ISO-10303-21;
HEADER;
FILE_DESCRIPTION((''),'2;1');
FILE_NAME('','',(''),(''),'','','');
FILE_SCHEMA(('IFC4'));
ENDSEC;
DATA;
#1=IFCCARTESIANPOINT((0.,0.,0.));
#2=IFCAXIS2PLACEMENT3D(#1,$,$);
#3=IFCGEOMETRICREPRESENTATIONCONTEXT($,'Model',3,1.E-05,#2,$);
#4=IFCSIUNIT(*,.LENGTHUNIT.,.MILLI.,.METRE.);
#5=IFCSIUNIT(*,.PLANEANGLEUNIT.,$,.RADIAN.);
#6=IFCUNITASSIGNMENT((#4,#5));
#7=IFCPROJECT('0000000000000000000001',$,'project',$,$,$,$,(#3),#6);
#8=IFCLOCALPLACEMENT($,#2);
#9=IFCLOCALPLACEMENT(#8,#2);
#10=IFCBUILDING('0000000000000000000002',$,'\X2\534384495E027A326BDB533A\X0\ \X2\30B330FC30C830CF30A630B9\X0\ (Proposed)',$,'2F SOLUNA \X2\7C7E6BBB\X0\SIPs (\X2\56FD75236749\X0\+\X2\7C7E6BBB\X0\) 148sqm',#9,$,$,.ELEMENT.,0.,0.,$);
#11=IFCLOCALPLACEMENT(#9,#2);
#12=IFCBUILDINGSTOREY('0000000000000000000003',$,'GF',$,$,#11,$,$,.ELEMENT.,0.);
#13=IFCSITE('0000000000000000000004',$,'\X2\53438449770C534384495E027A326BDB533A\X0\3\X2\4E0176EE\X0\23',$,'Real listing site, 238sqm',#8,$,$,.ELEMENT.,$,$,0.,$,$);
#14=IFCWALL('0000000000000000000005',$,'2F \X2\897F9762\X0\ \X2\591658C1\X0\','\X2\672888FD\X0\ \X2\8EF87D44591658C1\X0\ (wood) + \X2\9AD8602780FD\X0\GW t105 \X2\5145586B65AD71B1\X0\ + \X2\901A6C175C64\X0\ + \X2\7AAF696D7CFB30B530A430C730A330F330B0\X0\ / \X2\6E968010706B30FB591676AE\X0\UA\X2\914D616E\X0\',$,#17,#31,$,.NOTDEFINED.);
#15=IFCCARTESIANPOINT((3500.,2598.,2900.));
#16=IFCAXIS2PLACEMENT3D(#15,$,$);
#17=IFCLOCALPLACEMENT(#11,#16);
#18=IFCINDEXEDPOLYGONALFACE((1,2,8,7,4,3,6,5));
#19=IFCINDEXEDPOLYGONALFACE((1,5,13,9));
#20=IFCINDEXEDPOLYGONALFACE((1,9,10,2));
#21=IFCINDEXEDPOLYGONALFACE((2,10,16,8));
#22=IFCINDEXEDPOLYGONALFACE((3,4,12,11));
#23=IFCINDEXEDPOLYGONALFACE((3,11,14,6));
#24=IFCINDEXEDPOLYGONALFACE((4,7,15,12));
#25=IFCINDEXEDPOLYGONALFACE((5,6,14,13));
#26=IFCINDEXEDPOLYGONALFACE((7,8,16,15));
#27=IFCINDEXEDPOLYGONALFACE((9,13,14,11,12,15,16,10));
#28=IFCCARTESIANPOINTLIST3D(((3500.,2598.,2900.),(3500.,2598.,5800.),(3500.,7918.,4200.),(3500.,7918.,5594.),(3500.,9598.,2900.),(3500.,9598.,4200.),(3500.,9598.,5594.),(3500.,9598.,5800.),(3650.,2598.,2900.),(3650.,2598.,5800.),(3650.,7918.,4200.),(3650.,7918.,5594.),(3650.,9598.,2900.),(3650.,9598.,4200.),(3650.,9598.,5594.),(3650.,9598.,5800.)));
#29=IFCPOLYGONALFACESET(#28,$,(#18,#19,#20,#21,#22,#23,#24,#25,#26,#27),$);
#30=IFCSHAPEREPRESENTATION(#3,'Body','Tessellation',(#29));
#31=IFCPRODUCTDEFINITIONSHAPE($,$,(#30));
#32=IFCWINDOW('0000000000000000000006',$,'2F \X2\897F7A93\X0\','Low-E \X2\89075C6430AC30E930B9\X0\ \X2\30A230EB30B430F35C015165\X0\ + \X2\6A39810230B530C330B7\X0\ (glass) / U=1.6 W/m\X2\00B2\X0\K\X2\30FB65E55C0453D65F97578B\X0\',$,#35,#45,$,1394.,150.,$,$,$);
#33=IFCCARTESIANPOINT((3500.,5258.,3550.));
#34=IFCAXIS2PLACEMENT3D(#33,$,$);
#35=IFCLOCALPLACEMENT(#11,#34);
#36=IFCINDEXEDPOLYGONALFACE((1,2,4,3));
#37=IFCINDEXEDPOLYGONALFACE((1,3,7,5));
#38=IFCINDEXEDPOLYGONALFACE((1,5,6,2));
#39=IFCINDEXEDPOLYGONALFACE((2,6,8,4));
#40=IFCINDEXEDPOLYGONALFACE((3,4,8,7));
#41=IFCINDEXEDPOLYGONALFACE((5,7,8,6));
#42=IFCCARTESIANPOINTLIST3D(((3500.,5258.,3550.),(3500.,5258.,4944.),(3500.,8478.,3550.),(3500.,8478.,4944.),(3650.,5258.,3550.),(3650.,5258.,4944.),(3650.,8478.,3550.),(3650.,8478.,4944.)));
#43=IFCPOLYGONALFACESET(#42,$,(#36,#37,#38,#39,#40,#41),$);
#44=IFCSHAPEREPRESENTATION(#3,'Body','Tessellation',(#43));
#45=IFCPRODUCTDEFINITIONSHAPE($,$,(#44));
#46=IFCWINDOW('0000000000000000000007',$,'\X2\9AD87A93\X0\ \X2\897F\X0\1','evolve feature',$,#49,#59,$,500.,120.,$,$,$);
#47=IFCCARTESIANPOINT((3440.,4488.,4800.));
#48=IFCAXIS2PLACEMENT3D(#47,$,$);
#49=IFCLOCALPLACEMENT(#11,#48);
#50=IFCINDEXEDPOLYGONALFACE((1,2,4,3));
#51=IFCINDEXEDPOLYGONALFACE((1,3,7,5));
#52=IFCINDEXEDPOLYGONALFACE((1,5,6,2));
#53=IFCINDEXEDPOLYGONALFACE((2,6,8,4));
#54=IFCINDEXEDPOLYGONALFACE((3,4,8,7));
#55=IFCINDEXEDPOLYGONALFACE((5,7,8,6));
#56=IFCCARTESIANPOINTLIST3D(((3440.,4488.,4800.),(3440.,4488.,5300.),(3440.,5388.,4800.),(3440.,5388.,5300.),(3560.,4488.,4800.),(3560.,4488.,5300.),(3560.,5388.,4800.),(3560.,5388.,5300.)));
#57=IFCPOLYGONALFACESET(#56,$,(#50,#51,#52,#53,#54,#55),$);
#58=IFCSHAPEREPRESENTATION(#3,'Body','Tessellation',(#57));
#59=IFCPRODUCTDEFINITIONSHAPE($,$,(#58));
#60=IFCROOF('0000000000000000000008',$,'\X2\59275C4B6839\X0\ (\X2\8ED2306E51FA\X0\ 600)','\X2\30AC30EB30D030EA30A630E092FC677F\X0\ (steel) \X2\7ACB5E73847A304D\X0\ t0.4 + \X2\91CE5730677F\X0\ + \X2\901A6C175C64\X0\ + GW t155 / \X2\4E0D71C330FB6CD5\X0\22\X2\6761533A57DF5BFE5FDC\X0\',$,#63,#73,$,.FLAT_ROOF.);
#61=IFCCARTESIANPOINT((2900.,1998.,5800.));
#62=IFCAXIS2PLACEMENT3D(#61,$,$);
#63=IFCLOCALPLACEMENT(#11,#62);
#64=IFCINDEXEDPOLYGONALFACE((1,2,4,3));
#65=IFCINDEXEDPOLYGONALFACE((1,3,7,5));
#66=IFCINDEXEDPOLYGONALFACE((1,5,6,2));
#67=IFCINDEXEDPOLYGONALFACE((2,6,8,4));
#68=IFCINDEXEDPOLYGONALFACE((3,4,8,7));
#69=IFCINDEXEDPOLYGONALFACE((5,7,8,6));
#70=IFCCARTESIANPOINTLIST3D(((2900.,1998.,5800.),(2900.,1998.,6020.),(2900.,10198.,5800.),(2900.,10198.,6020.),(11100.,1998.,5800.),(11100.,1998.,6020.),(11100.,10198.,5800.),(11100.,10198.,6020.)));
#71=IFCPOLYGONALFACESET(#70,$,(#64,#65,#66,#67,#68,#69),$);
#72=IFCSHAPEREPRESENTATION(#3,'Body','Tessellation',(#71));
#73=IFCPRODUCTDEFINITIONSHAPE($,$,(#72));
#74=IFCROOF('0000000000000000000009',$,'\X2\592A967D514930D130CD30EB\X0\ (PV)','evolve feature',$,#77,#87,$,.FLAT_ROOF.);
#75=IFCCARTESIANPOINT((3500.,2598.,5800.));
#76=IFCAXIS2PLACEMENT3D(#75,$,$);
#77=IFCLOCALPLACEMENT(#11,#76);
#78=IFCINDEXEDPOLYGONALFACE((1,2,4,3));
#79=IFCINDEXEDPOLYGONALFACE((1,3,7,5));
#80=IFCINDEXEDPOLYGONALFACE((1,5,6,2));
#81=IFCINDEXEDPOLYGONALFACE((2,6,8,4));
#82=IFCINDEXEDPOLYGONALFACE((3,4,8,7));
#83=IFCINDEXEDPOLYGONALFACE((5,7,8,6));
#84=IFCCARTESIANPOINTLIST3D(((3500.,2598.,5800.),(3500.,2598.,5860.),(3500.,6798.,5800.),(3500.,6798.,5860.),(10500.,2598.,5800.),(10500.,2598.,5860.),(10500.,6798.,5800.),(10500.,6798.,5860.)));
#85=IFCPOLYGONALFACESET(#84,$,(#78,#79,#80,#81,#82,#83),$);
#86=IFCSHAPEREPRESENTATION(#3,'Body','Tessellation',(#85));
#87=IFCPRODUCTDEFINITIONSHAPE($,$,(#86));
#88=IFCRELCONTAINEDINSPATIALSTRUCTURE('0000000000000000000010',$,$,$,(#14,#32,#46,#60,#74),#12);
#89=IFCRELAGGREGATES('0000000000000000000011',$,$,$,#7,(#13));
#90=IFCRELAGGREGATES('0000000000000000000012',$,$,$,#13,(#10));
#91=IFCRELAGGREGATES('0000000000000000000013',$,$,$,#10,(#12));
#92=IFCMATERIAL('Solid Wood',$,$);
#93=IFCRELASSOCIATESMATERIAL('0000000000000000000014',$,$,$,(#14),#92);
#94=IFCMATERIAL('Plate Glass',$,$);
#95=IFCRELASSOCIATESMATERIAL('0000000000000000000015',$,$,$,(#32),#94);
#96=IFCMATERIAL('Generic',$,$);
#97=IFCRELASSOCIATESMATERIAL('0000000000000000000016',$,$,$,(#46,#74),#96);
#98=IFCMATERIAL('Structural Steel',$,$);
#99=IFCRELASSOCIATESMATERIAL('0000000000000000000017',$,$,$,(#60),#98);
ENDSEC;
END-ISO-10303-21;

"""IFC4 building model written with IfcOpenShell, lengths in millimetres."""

from ifc_helpers import new_model, si_unit, frame, frame_2d, origin, place, context, project, spatial, rectangle, extrude, material, element, fill, save


model = new_model("IFC4")

# Units and contexts
model_context = context("Model", 3, precision=1e-05, world=origin())
ifc_project = project(units=[si_unit("LENGTHUNIT", "METRE", prefix="MILLI"), si_unit("PLANEANGLEUNIT", "RADIAN")], contexts=[model_context])

# Site, building, storey
site_placement = place(None, origin())
site = spatial("IfcSite", under=ifc_project, at=site_placement, Name="千葉県千葉市稲毛区3丁目23", ObjectType="Real listing site, 238sqm", CompositionType="ELEMENT", RefElevation=0.0)
building_placement = place(site_placement, origin())
building = spatial("IfcBuilding", under=site, at=building_placement, Name="千葉市稲毛区 コートハウス (Proposed)", ObjectType="2F SOLUNA 籾殻SIPs (国産杉+籾殻) 148sqm", CompositionType="ELEMENT", ElevationOfRefHeight=0.0, ElevationOfTerrain=0.0)
storey_placement = place(building_placement, origin())
storey = spatial("IfcBuildingStorey", under=building, at=storey_placement, Name="GF", CompositionType="ELEMENT", Elevation=0.0)

# Shared definitions
ifc_material_1 = material(Name="Solid Wood")
ifc_material_2 = material(Name="Generic")

# Shared definitions
ifc_material_3 = material(Name="Plate Glass")

# Wall, openings, windows
wall_1_placement = place(storey_placement, frame((3500.0, 2598.0, 2900.0)))
wall_1 = element("IfcWall", 1, at=wall_1_placement, inside=storey, material=ifc_material_1, Name="2F 西面 外壁", Description="木製 軸組外壁 (wood) + 高性能GW t105 充填断熱 + 通気層 + 窯業系サイディング / 準耐火・外皮UA配慮", PredefinedType="NOTDEFINED", context=model_context, shape_type="SweptSolid", body=[
    extrude(rectangle(XDim=150.0, YDim=7000.0, at=frame_2d((75.0, 3500.0))), frame((3500.0, 2598.0, 2900.0)), (0.0, 0.0, 1.0), 2900.0),
])
opening_1_placement = place(storey_placement, frame((3500.0, 5258.0, 3550.0)))
opening_1 = element("IfcOpeningElement", 2, at=opening_1_placement, cuts=wall_1, PredefinedType="NOTDEFINED", context=model_context, shape_type="SweptSolid", body=[
    extrude(rectangle(XDim=150.0, YDim=3220.0, at=frame_2d((75.0, 1610.0))), frame((3500.0, 5258.0, 3550.0)), (0.0, 0.0, 1.0), 1394.0),
])
opening_2_placement = place(storey_placement, frame((3440.0, 4488.0, 4800.0)))
opening_2 = element("IfcOpeningElement", 3, at=opening_2_placement, cuts=wall_1, PredefinedType="NOTDEFINED", context=model_context, shape_type="SweptSolid", body=[
    extrude(rectangle(XDim=120.0, YDim=900.0, at=frame_2d((60.0, 450.0))), frame((3440.0, 4488.0, 4800.0)), (0.0, 0.0, 1.0), 500.0),
])
window_1_placement = place(storey_placement, frame((3500.0, 5258.0, 3550.0)))
window_1 = element("IfcWindow", 4, at=window_1_placement, inside=storey, material=ifc_material_3, Name="2F 西窓", Description="Low-E 複層ガラス アルゴン封入 + 樹脂サッシ (glass) / U=1.6 W/m²K・日射取得型", OverallHeight=1394.0, OverallWidth=150.0, context=model_context, shape_type="SweptSolid", body=[
    extrude(rectangle(XDim=150.0, YDim=3220.0, at=frame_2d((75.0, 1610.0))), frame((3500.0, 5258.0, 3550.0)), (0.0, 0.0, 1.0), 1394.0),
])
fill(opening_1, window_1)
window_2_placement = place(storey_placement, frame((3440.0, 4488.0, 4800.0)))
window_2 = element("IfcWindow", 5, at=window_2_placement, inside=storey, material=ifc_material_2, Name="高窓 西1", Description="evolve feature", OverallHeight=500.0, OverallWidth=120.0, context=model_context, shape_type="SweptSolid", body=[
    extrude(rectangle(XDim=120.0, YDim=900.0, at=frame_2d((60.0, 450.0))), frame((3440.0, 4488.0, 4800.0)), (0.0, 0.0, 1.0), 500.0),
])
fill(opening_2, window_2)

# Roofs
ifc_material_4 = material(Name="Structural Steel")
roof_1_placement = place(storey_placement, frame((2900.0, 1998.0, 5800.0)))
element("IfcRoof", 6, at=roof_1_placement, inside=storey, material=ifc_material_4, Name="大屋根 (軒の出 600)", Description="ガルバリウム鋼板 (steel) 立平葺き t0.4 + 野地板 + 通気層 + GW t155 / 不燃・法22条区域対応", PredefinedType="FLAT_ROOF", context=model_context, shape_type="SweptSolid", body=[
    extrude(rectangle(XDim=8200.0, YDim=8200.0, at=frame_2d((4100.0, 4100.0))), frame((2900.0, 1998.0, 5800.0)), (0.0, 0.0, 1.0), 220.0),
])
roof_2_placement = place(storey_placement, frame((3500.0, 2598.0, 5800.0)))
element("IfcRoof", 7, at=roof_2_placement, inside=storey, material=ifc_material_2, Name="太陽光パネル (PV)", Description="evolve feature", PredefinedType="FLAT_ROOF", context=model_context, shape_type="SweptSolid", body=[
    extrude(rectangle(XDim=7000.0, YDim=4200.0, at=frame_2d((3500.0, 2100.0))), frame((3500.0, 2598.0, 5800.0)), (0.0, 0.0, 1.0), 60.0),
])

save(model, "model.ifc")
